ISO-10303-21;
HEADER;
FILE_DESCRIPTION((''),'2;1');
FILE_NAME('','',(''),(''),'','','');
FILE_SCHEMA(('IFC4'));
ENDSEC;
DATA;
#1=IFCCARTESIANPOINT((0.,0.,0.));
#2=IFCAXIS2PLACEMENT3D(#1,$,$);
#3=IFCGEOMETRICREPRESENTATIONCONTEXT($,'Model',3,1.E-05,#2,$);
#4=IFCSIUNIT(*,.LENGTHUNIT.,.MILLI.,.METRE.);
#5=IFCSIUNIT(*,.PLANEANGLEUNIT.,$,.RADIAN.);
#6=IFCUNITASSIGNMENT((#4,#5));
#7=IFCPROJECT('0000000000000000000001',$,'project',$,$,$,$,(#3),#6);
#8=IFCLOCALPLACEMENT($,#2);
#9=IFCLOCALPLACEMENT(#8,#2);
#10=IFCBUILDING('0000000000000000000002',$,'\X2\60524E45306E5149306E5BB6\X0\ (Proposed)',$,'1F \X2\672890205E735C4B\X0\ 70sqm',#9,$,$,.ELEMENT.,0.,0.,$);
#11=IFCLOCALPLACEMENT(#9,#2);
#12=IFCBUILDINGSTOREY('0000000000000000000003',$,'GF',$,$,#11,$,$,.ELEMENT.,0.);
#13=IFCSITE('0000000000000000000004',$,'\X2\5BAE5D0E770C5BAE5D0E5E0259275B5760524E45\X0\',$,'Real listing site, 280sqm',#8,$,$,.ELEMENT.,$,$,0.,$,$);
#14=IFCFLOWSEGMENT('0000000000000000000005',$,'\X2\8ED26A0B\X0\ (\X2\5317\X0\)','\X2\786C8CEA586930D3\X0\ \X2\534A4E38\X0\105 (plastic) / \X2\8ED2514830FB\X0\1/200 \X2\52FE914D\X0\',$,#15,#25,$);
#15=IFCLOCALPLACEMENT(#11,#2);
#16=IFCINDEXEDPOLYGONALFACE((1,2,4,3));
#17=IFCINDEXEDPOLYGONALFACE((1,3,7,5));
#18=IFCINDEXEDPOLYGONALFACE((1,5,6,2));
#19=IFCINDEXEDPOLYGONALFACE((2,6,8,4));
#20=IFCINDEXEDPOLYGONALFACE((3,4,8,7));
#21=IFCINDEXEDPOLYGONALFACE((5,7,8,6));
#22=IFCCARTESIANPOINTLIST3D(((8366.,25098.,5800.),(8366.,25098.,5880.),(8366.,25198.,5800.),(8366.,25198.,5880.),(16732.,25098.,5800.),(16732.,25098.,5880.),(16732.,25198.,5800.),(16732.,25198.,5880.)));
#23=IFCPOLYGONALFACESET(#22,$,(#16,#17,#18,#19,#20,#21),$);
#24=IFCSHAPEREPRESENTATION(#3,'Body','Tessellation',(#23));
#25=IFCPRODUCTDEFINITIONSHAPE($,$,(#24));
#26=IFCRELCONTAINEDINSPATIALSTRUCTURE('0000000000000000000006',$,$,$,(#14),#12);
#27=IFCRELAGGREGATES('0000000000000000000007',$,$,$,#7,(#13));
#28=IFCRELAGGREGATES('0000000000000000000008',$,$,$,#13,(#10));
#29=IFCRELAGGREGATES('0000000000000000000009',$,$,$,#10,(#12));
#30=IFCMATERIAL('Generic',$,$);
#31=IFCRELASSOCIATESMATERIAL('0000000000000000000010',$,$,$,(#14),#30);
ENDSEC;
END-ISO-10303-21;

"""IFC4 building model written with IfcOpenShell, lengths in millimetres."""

from ifc_helpers import new_model, si_unit, frame, frame_2d, origin, place, context, project, spatial, rectangle, extrude, material, element, save


model = new_model("IFC4")

# Units and contexts
model_context = context("Model", 3, precision=1e-05, world=origin())
ifc_project = project(units=[si_unit("LENGTHUNIT", "METRE", prefix="MILLI"), si_unit("PLANEANGLEUNIT", "RADIAN")], contexts=[model_context])

# Site, building, storey
site_placement = place(None, origin())
site = spatial("IfcSite", under=ifc_project, at=site_placement, Name="宮崎県宮崎市大字恒久", ObjectType="Real listing site, 280sqm", CompositionType="ELEMENT", RefElevation=0.0)
building_placement = place(site_placement, origin())
building = spatial("IfcBuilding", under=site, at=building_placement, Name="恒久の光の家 (Proposed)", ObjectType="1F 木造平屋 70sqm", CompositionType="ELEMENT", ElevationOfRefHeight=0.0, ElevationOfTerrain=0.0)
storey_placement = place(building_placement, origin())
storey = spatial("IfcBuildingStorey", under=building, at=storey_placement, Name="GF", CompositionType="ELEMENT", Elevation=0.0)

# Shared definitions
ifc_material_1 = material(Name="Generic")

# Flow segment
flow_segment_1_placement = place(storey_placement, frame((4183.0, 12549.0, 2900.0)))
element("IfcFlowSegment", 1, at=flow_segment_1_placement, inside=storey, material=ifc_material_1, Name="軒樋 (北)", Description="硬質塩ビ 半丸105 (plastic) / 軒先・1/200 勾配", context=model_context, shape_type="SweptSolid", body=[
    extrude(rectangle(XDim=8366.0, YDim=100.0, at=frame_2d((4183.0, 50.0))), frame((4183.0, 12549.0, 2900.0)), (0.0, 0.0, 1.0), 80.0),
])

save(model, "model.ifc")
